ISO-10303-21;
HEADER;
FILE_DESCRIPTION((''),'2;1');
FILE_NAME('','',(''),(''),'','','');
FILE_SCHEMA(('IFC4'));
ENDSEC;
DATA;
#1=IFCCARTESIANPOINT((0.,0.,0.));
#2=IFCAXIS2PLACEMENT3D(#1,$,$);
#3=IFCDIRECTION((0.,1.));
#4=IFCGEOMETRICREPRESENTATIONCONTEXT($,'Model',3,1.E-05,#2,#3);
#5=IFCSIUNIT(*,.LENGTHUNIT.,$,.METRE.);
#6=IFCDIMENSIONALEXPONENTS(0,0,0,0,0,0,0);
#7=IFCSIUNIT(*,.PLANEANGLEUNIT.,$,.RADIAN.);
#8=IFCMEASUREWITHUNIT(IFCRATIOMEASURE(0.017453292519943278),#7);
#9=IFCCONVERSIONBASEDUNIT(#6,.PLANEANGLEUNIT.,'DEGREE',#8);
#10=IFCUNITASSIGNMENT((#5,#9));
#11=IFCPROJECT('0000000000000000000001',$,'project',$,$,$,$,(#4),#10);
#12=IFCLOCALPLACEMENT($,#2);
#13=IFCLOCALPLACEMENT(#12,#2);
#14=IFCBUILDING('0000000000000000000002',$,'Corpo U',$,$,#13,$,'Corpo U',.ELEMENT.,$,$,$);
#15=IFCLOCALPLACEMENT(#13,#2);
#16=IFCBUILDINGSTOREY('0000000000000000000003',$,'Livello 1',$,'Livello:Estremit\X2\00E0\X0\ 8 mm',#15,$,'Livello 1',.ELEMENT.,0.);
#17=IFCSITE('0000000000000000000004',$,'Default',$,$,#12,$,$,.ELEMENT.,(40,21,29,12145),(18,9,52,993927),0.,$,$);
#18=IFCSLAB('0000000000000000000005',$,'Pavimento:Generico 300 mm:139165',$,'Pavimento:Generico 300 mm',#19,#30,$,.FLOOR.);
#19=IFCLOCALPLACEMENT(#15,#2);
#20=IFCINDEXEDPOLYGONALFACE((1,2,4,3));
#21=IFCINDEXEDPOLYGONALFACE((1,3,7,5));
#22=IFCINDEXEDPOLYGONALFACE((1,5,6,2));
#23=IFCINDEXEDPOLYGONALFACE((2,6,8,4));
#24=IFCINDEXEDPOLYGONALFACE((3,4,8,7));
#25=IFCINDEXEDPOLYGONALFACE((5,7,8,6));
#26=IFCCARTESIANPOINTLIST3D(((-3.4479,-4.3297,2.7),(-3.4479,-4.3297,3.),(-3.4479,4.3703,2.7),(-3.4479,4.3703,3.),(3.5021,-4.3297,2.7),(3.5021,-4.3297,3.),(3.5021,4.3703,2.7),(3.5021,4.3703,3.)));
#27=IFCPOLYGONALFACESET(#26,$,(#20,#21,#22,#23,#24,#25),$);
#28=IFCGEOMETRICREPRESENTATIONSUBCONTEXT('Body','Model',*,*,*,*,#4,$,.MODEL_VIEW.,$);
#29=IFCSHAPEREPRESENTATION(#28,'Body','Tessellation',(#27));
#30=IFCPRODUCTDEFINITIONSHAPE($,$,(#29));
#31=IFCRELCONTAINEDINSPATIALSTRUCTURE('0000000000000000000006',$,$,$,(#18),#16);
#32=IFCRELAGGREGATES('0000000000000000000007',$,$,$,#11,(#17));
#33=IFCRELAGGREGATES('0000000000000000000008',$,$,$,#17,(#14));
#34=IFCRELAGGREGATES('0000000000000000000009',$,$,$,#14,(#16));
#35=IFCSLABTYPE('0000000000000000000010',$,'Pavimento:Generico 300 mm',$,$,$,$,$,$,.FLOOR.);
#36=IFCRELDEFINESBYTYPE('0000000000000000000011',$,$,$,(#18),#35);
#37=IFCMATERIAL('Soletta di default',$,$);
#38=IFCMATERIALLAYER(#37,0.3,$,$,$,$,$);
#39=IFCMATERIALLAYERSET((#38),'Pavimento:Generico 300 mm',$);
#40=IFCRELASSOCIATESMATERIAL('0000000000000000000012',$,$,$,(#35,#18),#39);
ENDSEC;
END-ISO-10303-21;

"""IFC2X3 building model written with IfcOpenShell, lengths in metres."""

from ifc_helpers import new_model, entity, si_unit, converted_unit, direction, frame, frame_2d, origin, place, context, subcontext, project, spatial, rectangle, extrude, material, layer, layer_set, layer_usage, type_object, element, save


model = new_model("IFC2X3")

# Units and contexts
model_context = context("Model", 3, precision=1e-05, world=origin(), true_north=direction((0.0, 1.0)))
body_context = subcontext(model_context, "Body", "Model", "MODEL_VIEW")
ifc_project = project(units=[si_unit("LENGTHUNIT", "METRE"), converted_unit("PLANEANGLEUNIT", "DEGREE", entity("IfcRatioMeasure", 0.017453292519943278), si_unit("PLANEANGLEUNIT", "RADIAN"), dimensions=[0, 0, 0, 0, 0, 0, 0])], contexts=[model_context])

# Site, building, storey
site_placement = place(None, origin())
site = spatial("IfcSite", under=ifc_project, at=site_placement, Name="Default", CompositionType="ELEMENT", RefLatitude=(40, 21, 29, 12145), RefLongitude=(18, 9, 52, 993927), RefElevation=0.0)
building_placement = place(site_placement, origin())
building = spatial("IfcBuilding", under=site, at=building_placement, Name="Corpo U", LongName="Corpo U", CompositionType="ELEMENT")
storey_placement = place(building_placement, origin())
storey = spatial("IfcBuildingStorey", under=building, at=storey_placement, Name="Livello 1", ObjectType="Livello:Estremità 8 mm", LongName="Livello 1", CompositionType="ELEMENT", Elevation=0.0)

# Slab
ifc_material = material(Name="Soletta di default")
ifc_layer = layer(ifc_material, 0.3)
ifc_layer_set = layer_set([ifc_layer], Name="Pavimento:Generico 300 mm")
ifc_layer_usage = layer_usage(ifc_layer_set, "AXIS3", "POSITIVE", 0.0)
slab_type = type_object("IfcSlabType", Name="Pavimento:Generico 300 mm", PredefinedType="FLOOR", material=ifc_layer_set)
slab_placement = place(storey_placement, origin())
element("IfcSlab", 1, at=slab_placement, inside=storey, type_object=slab_type, material=ifc_layer_usage, Name="Pavimento:Generico 300 mm:139165", ObjectType="Pavimento:Generico 300 mm", PredefinedType="FLOOR", context=body_context, shape_type="SweptSolid", body=[
    extrude(rectangle(XDim=8.7, YDim=6.95, at=frame_2d((0.0, 0.0), x_axis=(1.0, 0.0))), frame((0.0271, 0.0203, 3.0), z_axis=(0.0, 0.0, -1.0), x_axis=(0.0, 1.0, 0.0)), (0.0, 0.0, 1.0), 0.3),
])

save(model, "model.ifc")
